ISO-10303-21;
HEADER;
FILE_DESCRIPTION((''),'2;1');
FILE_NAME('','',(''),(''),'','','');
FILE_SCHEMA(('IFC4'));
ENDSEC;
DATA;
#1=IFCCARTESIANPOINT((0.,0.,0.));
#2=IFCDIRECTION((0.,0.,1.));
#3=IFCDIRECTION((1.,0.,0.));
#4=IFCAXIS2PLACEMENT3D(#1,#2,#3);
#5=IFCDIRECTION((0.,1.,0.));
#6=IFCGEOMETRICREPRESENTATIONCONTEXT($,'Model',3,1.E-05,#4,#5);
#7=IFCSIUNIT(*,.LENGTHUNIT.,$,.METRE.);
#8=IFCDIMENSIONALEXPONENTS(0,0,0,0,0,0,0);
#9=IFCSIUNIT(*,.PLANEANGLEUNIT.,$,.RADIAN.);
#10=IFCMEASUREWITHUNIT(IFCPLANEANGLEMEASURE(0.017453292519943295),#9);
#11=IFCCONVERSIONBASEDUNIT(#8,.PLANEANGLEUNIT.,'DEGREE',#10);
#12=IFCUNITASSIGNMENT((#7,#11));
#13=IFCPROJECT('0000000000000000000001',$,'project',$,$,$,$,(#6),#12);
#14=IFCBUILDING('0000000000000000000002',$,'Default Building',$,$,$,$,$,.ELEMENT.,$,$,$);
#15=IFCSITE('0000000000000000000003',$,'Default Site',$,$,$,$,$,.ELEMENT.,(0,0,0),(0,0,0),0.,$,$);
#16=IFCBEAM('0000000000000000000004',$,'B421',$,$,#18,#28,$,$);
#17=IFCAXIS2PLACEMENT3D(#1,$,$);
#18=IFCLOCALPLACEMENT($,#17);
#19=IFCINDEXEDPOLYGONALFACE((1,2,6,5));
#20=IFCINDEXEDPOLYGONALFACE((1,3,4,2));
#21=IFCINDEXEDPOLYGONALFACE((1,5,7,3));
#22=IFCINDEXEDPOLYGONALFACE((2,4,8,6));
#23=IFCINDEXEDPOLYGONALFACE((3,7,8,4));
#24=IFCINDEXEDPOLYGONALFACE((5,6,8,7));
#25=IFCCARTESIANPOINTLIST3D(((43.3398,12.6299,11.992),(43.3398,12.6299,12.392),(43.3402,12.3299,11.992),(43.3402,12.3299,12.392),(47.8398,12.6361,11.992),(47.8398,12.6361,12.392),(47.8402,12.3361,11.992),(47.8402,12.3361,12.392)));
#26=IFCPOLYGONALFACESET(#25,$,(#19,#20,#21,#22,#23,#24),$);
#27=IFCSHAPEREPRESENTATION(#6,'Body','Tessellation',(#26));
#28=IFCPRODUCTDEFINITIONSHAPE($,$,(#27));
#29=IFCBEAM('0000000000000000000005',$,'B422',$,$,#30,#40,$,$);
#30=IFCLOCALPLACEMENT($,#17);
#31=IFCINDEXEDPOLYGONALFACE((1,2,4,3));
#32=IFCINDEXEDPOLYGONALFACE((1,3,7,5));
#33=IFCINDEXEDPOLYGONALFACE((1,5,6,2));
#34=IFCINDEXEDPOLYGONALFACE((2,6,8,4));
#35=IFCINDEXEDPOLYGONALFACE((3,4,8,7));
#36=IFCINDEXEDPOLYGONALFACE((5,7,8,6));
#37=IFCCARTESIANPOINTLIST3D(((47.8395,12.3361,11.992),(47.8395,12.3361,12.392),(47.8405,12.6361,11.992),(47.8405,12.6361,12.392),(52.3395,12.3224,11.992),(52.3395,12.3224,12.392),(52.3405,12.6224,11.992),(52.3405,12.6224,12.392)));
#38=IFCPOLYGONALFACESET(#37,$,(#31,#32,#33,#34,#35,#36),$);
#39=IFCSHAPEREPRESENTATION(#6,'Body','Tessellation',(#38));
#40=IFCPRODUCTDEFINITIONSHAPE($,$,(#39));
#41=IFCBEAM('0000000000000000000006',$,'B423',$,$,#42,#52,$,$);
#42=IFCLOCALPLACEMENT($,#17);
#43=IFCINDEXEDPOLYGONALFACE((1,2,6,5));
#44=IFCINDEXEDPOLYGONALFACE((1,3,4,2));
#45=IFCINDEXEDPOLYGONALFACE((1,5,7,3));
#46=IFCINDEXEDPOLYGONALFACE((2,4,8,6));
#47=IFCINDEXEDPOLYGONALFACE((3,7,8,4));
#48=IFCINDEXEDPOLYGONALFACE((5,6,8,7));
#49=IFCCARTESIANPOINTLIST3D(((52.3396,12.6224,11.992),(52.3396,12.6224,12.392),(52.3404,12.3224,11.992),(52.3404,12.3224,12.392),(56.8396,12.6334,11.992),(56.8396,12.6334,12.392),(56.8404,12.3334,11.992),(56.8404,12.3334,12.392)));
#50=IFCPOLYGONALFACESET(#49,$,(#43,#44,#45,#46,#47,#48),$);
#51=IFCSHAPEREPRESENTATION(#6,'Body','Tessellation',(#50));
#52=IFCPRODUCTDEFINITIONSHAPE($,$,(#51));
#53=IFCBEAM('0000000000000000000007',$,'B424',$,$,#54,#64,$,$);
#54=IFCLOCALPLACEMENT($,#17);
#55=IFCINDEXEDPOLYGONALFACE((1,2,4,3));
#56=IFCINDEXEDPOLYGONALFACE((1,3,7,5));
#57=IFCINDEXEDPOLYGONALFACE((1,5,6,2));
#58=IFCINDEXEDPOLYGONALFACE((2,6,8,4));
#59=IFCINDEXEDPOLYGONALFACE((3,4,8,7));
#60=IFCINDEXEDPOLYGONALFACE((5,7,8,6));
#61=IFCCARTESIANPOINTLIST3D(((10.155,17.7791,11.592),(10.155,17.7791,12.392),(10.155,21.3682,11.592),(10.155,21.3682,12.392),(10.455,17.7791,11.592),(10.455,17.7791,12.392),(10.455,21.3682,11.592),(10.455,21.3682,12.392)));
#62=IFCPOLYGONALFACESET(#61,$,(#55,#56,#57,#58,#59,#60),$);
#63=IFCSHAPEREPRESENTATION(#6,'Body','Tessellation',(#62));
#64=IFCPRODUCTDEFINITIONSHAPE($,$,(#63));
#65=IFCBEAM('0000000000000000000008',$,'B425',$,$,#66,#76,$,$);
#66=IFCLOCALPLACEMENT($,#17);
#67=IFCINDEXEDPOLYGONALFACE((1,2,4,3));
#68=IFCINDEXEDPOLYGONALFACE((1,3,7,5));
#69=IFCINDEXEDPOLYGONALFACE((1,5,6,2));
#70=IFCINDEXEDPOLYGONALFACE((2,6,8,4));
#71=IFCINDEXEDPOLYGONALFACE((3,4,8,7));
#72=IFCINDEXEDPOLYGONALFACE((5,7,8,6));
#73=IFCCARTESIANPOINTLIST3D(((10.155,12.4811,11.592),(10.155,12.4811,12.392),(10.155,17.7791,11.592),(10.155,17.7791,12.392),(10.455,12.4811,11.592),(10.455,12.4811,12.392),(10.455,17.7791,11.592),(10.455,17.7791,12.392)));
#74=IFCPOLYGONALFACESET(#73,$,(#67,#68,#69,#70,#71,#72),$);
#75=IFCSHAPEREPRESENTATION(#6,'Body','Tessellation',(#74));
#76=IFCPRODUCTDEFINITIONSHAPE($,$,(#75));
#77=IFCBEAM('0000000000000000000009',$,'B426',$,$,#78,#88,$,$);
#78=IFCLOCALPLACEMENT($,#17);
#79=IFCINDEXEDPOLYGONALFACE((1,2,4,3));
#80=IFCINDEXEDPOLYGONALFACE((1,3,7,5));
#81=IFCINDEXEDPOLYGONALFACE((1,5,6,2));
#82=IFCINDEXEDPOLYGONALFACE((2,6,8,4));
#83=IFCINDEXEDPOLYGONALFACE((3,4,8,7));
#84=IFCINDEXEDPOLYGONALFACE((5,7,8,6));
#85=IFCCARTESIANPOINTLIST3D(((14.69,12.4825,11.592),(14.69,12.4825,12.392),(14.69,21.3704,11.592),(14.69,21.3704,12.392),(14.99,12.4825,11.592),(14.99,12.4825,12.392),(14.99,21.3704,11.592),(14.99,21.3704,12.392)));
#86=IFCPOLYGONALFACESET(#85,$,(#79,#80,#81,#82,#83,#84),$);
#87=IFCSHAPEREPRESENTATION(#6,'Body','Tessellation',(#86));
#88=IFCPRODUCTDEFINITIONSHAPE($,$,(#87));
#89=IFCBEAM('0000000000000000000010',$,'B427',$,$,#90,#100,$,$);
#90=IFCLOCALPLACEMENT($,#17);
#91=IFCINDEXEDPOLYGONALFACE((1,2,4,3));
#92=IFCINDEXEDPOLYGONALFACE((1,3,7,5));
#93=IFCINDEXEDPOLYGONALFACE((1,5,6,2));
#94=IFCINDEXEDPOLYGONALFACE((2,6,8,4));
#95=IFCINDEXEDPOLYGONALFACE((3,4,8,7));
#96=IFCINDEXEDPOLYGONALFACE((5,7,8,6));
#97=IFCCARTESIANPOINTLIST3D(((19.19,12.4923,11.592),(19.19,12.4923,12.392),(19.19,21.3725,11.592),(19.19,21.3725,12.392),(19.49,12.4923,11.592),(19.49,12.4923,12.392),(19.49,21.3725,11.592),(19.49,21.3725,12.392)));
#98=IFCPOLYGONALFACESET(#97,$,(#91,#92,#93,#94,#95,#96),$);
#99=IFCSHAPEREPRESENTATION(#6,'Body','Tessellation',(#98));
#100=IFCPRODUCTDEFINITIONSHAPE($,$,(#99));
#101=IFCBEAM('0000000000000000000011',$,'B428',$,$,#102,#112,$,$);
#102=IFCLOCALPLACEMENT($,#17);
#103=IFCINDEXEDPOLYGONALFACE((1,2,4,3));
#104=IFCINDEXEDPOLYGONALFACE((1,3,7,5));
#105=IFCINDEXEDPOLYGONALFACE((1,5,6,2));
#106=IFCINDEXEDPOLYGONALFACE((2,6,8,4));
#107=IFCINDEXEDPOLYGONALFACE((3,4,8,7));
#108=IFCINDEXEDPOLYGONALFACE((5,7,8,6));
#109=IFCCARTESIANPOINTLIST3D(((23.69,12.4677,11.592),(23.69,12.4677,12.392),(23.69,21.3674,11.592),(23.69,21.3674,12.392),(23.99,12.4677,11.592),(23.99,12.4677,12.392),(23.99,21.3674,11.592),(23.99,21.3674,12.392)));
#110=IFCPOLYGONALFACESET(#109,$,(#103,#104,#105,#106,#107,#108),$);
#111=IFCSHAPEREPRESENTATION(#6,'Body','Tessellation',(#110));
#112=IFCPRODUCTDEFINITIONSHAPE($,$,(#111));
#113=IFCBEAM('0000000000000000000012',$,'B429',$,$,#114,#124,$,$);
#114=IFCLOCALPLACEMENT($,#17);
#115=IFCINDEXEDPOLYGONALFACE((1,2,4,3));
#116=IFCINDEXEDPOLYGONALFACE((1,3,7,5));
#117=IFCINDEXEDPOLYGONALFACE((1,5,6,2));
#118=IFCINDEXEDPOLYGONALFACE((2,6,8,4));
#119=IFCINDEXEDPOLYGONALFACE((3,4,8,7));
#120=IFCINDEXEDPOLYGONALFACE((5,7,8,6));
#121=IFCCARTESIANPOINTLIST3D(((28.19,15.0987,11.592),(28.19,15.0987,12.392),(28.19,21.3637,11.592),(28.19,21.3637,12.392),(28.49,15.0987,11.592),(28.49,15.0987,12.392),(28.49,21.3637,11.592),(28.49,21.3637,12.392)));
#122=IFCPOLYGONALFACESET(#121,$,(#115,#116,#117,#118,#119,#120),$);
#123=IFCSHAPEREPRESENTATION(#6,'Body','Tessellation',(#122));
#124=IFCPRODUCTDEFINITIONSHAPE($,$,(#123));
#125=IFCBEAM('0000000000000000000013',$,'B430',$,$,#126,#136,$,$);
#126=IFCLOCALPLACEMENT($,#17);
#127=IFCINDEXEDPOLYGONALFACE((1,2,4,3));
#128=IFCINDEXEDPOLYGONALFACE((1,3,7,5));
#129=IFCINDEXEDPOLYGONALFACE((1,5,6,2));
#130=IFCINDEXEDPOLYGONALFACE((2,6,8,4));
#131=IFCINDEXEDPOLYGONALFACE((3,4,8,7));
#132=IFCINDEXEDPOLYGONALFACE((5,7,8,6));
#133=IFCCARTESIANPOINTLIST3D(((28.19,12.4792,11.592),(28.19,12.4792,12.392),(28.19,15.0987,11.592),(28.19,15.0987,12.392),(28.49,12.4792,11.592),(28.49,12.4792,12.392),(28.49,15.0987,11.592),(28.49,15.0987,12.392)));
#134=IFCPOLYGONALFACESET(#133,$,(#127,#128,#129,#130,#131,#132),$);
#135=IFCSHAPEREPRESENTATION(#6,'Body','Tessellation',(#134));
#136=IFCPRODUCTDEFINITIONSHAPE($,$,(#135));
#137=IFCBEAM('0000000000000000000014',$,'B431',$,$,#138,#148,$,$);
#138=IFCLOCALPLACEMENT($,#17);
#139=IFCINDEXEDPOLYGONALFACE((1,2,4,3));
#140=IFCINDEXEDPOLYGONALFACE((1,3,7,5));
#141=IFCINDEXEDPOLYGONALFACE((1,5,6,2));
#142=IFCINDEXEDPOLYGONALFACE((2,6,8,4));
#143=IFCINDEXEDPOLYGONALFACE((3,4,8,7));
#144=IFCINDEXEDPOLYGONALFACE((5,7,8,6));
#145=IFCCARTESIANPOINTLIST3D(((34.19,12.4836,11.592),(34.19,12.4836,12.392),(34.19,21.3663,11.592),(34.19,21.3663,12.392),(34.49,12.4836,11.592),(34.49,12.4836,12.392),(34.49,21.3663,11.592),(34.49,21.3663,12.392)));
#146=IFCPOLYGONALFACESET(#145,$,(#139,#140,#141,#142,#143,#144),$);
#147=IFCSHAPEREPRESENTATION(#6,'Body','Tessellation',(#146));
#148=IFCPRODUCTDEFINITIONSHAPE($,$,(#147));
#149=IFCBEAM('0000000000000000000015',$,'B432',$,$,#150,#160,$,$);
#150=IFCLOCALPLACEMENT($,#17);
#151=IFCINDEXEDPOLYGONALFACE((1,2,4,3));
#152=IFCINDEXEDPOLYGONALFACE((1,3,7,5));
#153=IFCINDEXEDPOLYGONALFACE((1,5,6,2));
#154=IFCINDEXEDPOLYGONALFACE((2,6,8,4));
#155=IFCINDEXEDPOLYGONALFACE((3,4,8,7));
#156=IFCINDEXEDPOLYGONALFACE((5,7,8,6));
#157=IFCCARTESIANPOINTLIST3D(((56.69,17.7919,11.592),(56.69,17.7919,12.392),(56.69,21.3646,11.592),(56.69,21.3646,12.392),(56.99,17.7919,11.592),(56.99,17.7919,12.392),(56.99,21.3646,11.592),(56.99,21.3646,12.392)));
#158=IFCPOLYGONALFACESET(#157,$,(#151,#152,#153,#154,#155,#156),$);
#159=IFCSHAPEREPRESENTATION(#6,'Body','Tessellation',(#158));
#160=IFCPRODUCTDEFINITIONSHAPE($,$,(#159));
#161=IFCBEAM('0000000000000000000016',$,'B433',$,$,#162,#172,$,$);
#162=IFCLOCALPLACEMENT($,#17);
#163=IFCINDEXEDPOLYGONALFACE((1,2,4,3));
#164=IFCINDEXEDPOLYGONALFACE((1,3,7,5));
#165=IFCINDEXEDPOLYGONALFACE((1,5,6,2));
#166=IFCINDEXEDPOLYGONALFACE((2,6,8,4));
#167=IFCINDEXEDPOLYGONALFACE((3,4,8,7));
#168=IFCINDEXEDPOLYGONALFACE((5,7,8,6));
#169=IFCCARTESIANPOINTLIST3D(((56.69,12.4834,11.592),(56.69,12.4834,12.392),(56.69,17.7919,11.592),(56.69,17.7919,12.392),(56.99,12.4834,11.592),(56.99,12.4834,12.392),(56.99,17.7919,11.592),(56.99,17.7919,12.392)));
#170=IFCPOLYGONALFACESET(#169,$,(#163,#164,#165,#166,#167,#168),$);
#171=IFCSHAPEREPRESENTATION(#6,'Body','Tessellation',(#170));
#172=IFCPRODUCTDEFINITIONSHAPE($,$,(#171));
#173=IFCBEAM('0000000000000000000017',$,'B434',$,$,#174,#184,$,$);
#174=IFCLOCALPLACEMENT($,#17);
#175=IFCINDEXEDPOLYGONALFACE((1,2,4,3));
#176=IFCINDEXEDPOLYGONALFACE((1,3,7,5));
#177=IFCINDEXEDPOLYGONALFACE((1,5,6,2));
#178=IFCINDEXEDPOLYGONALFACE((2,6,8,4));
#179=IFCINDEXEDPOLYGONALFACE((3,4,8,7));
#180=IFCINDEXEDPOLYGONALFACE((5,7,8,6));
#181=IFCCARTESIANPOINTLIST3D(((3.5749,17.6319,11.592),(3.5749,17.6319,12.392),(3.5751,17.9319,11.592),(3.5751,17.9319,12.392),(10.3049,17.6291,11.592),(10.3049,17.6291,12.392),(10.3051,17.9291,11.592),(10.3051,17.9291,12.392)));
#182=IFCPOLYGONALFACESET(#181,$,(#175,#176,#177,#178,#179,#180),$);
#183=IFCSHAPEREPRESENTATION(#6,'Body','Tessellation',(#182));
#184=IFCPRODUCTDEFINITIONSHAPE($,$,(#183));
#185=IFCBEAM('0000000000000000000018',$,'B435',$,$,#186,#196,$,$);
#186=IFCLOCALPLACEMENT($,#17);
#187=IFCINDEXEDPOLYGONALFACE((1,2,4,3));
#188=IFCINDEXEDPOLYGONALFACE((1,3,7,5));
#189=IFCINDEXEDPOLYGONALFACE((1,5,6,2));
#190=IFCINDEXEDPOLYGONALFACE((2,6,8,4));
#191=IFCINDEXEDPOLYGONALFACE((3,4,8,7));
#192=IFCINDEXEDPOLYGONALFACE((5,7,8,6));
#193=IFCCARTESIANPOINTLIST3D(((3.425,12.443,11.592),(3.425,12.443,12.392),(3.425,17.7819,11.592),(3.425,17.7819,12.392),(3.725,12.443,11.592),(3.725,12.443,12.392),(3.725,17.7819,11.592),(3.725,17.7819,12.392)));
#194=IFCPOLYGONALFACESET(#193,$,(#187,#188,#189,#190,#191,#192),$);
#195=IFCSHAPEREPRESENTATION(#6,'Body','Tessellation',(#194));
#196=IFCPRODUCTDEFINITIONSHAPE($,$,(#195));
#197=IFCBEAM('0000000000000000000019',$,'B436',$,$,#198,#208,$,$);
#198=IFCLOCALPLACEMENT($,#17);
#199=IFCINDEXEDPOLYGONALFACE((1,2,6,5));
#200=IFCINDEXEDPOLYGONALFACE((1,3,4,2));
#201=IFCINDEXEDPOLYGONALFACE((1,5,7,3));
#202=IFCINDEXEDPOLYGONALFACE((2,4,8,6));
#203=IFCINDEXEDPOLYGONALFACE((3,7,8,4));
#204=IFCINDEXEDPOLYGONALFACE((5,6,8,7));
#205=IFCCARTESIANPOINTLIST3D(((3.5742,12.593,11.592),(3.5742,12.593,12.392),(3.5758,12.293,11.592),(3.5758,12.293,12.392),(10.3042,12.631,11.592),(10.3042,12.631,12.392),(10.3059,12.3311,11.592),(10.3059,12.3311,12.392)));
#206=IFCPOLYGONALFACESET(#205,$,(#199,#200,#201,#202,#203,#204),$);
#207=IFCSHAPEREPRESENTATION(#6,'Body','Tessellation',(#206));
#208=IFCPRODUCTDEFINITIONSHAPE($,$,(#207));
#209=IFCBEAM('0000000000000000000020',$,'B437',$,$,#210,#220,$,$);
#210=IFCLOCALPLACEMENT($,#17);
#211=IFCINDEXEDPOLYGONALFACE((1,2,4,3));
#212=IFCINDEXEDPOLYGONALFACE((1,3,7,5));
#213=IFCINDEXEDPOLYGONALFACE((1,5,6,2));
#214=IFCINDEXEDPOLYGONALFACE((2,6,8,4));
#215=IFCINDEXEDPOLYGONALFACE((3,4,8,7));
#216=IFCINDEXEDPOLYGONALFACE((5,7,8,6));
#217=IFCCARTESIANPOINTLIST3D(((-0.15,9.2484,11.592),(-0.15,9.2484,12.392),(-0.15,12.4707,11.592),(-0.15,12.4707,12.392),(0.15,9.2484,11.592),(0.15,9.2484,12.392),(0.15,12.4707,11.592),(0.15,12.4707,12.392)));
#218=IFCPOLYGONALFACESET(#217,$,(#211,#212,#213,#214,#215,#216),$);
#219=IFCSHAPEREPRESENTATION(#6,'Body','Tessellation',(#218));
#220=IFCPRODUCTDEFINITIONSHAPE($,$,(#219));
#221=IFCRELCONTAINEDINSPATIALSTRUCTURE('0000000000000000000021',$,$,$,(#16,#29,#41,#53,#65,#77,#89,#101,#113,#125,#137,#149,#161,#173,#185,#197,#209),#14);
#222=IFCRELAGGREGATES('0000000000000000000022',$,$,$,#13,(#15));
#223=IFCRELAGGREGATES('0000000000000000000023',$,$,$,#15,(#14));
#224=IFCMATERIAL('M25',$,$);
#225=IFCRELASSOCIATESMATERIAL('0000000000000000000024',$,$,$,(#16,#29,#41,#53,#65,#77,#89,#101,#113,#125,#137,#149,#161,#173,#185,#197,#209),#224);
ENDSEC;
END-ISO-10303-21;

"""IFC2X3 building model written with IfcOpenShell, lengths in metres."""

from ifc_helpers import new_model, entity, si_unit, converted_unit, direction, frame, frame_2d, origin_with_axes, place, context, project, spatial, rectangle, extrude, material, element, save


model = new_model("IFC2X3")

# Units and contexts
model_context = context("Model", 3, precision=1e-05, world=origin_with_axes(), true_north=direction((0.0, 1.0, 0.0)))
ifc_project = project(units=[si_unit("LENGTHUNIT", "METRE"), converted_unit("PLANEANGLEUNIT", "DEGREE", entity("IfcPlaneAngleMeasure", 0.017453292519943295), si_unit("PLANEANGLEUNIT", "RADIAN"), dimensions=[0, 0, 0, 0, 0, 0, 0])], contexts=[model_context])

# Site, building
site = spatial("IfcSite", under=ifc_project, Name="Default Site", CompositionType="ELEMENT", RefLatitude=(0, 0, 0), RefLongitude=(0, 0, 0), RefElevation=0.0)
building = spatial("IfcBuilding", under=site, Name="Default Building", CompositionType="ELEMENT")

# Beams
ifc_material = material(Name="M25")
placement = place(None, origin_with_axes())
element("IfcBeam", 1, at=placement, inside=building, material=ifc_material, Name="B421", context=model_context, shape_type="SweptSolid", body=[
    extrude(rectangle(XDim=0.3, YDim=0.4, at=frame_2d((0.0, 0.0), x_axis=(0.0, 1.0, 0.0))), frame((43.34, 12.4799, 12.192), z_axis=(0.999999, 0.001374, 0.0), x_axis=(0.0, 0.0, -1.0)), (0.0, 0.0, 1.0), 4.5),
])
element("IfcBeam", 2, at=placement, inside=building, material=ifc_material, Name="B422", context=model_context, shape_type="SweptSolid", body=[
    extrude(rectangle(XDim=0.3, YDim=0.4, at=frame_2d((0.0, 0.0), x_axis=(0.0, 1.0, 0.0))), frame((47.84, 12.4861, 12.192), z_axis=(0.999995, -0.003045, 0.0), x_axis=(0.0, 0.0, -1.0)), (0.0, 0.0, 1.0), 4.5),
])
element("IfcBeam", 3, at=placement, inside=building, material=ifc_material, Name="B423", context=model_context, shape_type="SweptSolid", body=[
    extrude(rectangle(XDim=0.3, YDim=0.4, at=frame_2d((0.0, 0.0), x_axis=(0.0, 1.0, 0.0))), frame((52.34, 12.4724, 12.192), z_axis=(0.999997, 0.002456, 0.0), x_axis=(0.0, 0.0, -1.0)), (0.0, 0.0, 1.0), 4.5),
])
element("IfcBeam", 4, at=placement, inside=building, material=ifc_material, Name="B424", context=model_context, shape_type="SweptSolid", body=[
    extrude(rectangle(XDim=0.3, YDim=0.8, at=frame_2d((0.0, 0.0), x_axis=(0.0, 1.0, 0.0))), frame((10.305, 21.3682, 11.992), z_axis=(0.0, -1.0, 0.0), x_axis=(0.0, 0.0, -1.0)), (0.0, 0.0, 1.0), 3.5891),
])
element("IfcBeam", 5, at=placement, inside=building, material=ifc_material, Name="B425", context=model_context, shape_type="SweptSolid", body=[
    extrude(rectangle(XDim=0.3, YDim=0.8, at=frame_2d((0.0, 0.0), x_axis=(0.0, 1.0, 0.0))), frame((10.305, 17.7791, 11.992), z_axis=(0.0, -1.0, 0.0), x_axis=(0.0, 0.0, -1.0)), (0.0, 0.0, 1.0), 5.298),
])
element("IfcBeam", 6, at=placement, inside=building, material=ifc_material, Name="B426", context=model_context, shape_type="SweptSolid", body=[
    extrude(rectangle(XDim=0.3, YDim=0.8, at=frame_2d((0.0, 0.0), x_axis=(0.0, 1.0, 0.0))), frame((14.84, 21.3704, 11.992), z_axis=(0.0, -1.0, 0.0), x_axis=(0.0, 0.0, -1.0)), (0.0, 0.0, 1.0), 8.8879),
])
element("IfcBeam", 7, at=placement, inside=building, material=ifc_material, Name="B427", context=model_context, shape_type="SweptSolid", body=[
    extrude(rectangle(XDim=0.3, YDim=0.8, at=frame_2d((0.0, 0.0), x_axis=(0.0, 1.0, 0.0))), frame((19.34, 21.3725, 11.992), z_axis=(0.0, -1.0, 0.0), x_axis=(0.0, 0.0, -1.0)), (0.0, 0.0, 1.0), 8.8802),
])
element("IfcBeam", 8, at=placement, inside=building, material=ifc_material, Name="B428", context=model_context, shape_type="SweptSolid", body=[
    extrude(rectangle(XDim=0.3, YDim=0.8, at=frame_2d((0.0, 0.0), x_axis=(0.0, 1.0, 0.0))), frame((23.84, 21.3674, 11.992), z_axis=(0.0, -1.0, 0.0), x_axis=(0.0, 0.0, -1.0)), (0.0, 0.0, 1.0), 8.8997),
])
element("IfcBeam", 9, at=placement, inside=building, material=ifc_material, Name="B429", context=model_context, shape_type="SweptSolid", body=[
    extrude(rectangle(XDim=0.3, YDim=0.8, at=frame_2d((0.0, 0.0), x_axis=(0.0, 1.0, 0.0))), frame((28.34, 21.3637, 11.992), z_axis=(0.0, -1.0, 0.0), x_axis=(0.0, 0.0, -1.0)), (0.0, 0.0, 1.0), 6.265),
])
element("IfcBeam", 10, at=placement, inside=building, material=ifc_material, Name="B430", context=model_context, shape_type="SweptSolid", body=[
    extrude(rectangle(XDim=0.3, YDim=0.8, at=frame_2d((0.0, 0.0), x_axis=(0.0, 1.0, 0.0))), frame((28.34, 15.0987, 11.992), z_axis=(0.0, -1.0, 0.0), x_axis=(0.0, 0.0, -1.0)), (0.0, 0.0, 1.0), 2.6195),
])
element("IfcBeam", 11, at=placement, inside=building, material=ifc_material, Name="B431", context=model_context, shape_type="SweptSolid", body=[
    extrude(rectangle(XDim=0.3, YDim=0.8, at=frame_2d((0.0, 0.0), x_axis=(0.0, 1.0, 0.0))), frame((34.34, 12.4836, 11.992), z_axis=(0.0, 1.0, 0.0), x_axis=(0.0, 0.0, -1.0)), (0.0, 0.0, 1.0), 8.8827),
])
element("IfcBeam", 12, at=placement, inside=building, material=ifc_material, Name="B432", context=model_context, shape_type="SweptSolid", body=[
    extrude(rectangle(XDim=0.3, YDim=0.8, at=frame_2d((0.0, 0.0), x_axis=(0.0, 1.0, 0.0))), frame((56.84, 17.7919, 11.992), z_axis=(0.0, 1.0, 0.0), x_axis=(0.0, 0.0, -1.0)), (0.0, 0.0, 1.0), 3.5727),
])
element("IfcBeam", 13, at=placement, inside=building, material=ifc_material, Name="B433", context=model_context, shape_type="SweptSolid", body=[
    extrude(rectangle(XDim=0.3, YDim=0.8, at=frame_2d((0.0, 0.0), x_axis=(0.0, 1.0, 0.0))), frame((56.84, 12.4834, 11.992), z_axis=(0.0, 1.0, 0.0), x_axis=(0.0, 0.0, -1.0)), (0.0, 0.0, 1.0), 5.3085),
])
element("IfcBeam", 14, at=placement, inside=building, material=ifc_material, Name="B434", context=model_context, shape_type="SweptSolid", body=[
    extrude(rectangle(XDim=0.3, YDim=0.8, at=frame_2d((0.0, 0.0), x_axis=(0.0, 1.0, 0.0))), frame((10.305, 17.7791, 11.992), z_axis=(-1.0, 0.000419, 0.0), x_axis=(0.0, 0.0, -1.0)), (0.0, 0.0, 1.0), 6.73),
])
element("IfcBeam", 15, at=placement, inside=building, material=ifc_material, Name="B435", context=model_context, shape_type="SweptSolid", body=[
    extrude(rectangle(XDim=0.3, YDim=0.8, at=frame_2d((0.0, 0.0), x_axis=(0.0, 1.0, 0.0))), frame((3.575, 12.443, 11.992), z_axis=(0.0, 1.0, 0.0), x_axis=(0.0, 0.0, -1.0)), (0.0, 0.0, 1.0), 5.3389),
])
element("IfcBeam", 16, at=placement, inside=building, material=ifc_material, Name="B436", context=model_context, shape_type="SweptSolid", body=[
    extrude(rectangle(XDim=0.3, YDim=0.8, at=frame_2d((0.0, 0.0), x_axis=(0.0, 1.0, 0.0))), frame((3.575, 12.443, 11.992), z_axis=(0.999984, 0.005654, 0.0), x_axis=(0.0, 0.0, -1.0)), (0.0, 0.0, 1.0), 6.7301),
])
element("IfcBeam", 17, at=placement, inside=building, material=ifc_material, Name="B437", context=model_context, shape_type="SweptSolid", body=[
    extrude(rectangle(XDim=0.3, YDim=0.8, at=frame_2d((0.0, 0.0), x_axis=(0.0, 1.0, 0.0))), frame((0.0, 9.2484, 11.992), z_axis=(0.0, 1.0, 0.0), x_axis=(0.0, 0.0, -1.0)), (0.0, 0.0, 1.0), 3.2223),
])

save(model, "model.ifc")
